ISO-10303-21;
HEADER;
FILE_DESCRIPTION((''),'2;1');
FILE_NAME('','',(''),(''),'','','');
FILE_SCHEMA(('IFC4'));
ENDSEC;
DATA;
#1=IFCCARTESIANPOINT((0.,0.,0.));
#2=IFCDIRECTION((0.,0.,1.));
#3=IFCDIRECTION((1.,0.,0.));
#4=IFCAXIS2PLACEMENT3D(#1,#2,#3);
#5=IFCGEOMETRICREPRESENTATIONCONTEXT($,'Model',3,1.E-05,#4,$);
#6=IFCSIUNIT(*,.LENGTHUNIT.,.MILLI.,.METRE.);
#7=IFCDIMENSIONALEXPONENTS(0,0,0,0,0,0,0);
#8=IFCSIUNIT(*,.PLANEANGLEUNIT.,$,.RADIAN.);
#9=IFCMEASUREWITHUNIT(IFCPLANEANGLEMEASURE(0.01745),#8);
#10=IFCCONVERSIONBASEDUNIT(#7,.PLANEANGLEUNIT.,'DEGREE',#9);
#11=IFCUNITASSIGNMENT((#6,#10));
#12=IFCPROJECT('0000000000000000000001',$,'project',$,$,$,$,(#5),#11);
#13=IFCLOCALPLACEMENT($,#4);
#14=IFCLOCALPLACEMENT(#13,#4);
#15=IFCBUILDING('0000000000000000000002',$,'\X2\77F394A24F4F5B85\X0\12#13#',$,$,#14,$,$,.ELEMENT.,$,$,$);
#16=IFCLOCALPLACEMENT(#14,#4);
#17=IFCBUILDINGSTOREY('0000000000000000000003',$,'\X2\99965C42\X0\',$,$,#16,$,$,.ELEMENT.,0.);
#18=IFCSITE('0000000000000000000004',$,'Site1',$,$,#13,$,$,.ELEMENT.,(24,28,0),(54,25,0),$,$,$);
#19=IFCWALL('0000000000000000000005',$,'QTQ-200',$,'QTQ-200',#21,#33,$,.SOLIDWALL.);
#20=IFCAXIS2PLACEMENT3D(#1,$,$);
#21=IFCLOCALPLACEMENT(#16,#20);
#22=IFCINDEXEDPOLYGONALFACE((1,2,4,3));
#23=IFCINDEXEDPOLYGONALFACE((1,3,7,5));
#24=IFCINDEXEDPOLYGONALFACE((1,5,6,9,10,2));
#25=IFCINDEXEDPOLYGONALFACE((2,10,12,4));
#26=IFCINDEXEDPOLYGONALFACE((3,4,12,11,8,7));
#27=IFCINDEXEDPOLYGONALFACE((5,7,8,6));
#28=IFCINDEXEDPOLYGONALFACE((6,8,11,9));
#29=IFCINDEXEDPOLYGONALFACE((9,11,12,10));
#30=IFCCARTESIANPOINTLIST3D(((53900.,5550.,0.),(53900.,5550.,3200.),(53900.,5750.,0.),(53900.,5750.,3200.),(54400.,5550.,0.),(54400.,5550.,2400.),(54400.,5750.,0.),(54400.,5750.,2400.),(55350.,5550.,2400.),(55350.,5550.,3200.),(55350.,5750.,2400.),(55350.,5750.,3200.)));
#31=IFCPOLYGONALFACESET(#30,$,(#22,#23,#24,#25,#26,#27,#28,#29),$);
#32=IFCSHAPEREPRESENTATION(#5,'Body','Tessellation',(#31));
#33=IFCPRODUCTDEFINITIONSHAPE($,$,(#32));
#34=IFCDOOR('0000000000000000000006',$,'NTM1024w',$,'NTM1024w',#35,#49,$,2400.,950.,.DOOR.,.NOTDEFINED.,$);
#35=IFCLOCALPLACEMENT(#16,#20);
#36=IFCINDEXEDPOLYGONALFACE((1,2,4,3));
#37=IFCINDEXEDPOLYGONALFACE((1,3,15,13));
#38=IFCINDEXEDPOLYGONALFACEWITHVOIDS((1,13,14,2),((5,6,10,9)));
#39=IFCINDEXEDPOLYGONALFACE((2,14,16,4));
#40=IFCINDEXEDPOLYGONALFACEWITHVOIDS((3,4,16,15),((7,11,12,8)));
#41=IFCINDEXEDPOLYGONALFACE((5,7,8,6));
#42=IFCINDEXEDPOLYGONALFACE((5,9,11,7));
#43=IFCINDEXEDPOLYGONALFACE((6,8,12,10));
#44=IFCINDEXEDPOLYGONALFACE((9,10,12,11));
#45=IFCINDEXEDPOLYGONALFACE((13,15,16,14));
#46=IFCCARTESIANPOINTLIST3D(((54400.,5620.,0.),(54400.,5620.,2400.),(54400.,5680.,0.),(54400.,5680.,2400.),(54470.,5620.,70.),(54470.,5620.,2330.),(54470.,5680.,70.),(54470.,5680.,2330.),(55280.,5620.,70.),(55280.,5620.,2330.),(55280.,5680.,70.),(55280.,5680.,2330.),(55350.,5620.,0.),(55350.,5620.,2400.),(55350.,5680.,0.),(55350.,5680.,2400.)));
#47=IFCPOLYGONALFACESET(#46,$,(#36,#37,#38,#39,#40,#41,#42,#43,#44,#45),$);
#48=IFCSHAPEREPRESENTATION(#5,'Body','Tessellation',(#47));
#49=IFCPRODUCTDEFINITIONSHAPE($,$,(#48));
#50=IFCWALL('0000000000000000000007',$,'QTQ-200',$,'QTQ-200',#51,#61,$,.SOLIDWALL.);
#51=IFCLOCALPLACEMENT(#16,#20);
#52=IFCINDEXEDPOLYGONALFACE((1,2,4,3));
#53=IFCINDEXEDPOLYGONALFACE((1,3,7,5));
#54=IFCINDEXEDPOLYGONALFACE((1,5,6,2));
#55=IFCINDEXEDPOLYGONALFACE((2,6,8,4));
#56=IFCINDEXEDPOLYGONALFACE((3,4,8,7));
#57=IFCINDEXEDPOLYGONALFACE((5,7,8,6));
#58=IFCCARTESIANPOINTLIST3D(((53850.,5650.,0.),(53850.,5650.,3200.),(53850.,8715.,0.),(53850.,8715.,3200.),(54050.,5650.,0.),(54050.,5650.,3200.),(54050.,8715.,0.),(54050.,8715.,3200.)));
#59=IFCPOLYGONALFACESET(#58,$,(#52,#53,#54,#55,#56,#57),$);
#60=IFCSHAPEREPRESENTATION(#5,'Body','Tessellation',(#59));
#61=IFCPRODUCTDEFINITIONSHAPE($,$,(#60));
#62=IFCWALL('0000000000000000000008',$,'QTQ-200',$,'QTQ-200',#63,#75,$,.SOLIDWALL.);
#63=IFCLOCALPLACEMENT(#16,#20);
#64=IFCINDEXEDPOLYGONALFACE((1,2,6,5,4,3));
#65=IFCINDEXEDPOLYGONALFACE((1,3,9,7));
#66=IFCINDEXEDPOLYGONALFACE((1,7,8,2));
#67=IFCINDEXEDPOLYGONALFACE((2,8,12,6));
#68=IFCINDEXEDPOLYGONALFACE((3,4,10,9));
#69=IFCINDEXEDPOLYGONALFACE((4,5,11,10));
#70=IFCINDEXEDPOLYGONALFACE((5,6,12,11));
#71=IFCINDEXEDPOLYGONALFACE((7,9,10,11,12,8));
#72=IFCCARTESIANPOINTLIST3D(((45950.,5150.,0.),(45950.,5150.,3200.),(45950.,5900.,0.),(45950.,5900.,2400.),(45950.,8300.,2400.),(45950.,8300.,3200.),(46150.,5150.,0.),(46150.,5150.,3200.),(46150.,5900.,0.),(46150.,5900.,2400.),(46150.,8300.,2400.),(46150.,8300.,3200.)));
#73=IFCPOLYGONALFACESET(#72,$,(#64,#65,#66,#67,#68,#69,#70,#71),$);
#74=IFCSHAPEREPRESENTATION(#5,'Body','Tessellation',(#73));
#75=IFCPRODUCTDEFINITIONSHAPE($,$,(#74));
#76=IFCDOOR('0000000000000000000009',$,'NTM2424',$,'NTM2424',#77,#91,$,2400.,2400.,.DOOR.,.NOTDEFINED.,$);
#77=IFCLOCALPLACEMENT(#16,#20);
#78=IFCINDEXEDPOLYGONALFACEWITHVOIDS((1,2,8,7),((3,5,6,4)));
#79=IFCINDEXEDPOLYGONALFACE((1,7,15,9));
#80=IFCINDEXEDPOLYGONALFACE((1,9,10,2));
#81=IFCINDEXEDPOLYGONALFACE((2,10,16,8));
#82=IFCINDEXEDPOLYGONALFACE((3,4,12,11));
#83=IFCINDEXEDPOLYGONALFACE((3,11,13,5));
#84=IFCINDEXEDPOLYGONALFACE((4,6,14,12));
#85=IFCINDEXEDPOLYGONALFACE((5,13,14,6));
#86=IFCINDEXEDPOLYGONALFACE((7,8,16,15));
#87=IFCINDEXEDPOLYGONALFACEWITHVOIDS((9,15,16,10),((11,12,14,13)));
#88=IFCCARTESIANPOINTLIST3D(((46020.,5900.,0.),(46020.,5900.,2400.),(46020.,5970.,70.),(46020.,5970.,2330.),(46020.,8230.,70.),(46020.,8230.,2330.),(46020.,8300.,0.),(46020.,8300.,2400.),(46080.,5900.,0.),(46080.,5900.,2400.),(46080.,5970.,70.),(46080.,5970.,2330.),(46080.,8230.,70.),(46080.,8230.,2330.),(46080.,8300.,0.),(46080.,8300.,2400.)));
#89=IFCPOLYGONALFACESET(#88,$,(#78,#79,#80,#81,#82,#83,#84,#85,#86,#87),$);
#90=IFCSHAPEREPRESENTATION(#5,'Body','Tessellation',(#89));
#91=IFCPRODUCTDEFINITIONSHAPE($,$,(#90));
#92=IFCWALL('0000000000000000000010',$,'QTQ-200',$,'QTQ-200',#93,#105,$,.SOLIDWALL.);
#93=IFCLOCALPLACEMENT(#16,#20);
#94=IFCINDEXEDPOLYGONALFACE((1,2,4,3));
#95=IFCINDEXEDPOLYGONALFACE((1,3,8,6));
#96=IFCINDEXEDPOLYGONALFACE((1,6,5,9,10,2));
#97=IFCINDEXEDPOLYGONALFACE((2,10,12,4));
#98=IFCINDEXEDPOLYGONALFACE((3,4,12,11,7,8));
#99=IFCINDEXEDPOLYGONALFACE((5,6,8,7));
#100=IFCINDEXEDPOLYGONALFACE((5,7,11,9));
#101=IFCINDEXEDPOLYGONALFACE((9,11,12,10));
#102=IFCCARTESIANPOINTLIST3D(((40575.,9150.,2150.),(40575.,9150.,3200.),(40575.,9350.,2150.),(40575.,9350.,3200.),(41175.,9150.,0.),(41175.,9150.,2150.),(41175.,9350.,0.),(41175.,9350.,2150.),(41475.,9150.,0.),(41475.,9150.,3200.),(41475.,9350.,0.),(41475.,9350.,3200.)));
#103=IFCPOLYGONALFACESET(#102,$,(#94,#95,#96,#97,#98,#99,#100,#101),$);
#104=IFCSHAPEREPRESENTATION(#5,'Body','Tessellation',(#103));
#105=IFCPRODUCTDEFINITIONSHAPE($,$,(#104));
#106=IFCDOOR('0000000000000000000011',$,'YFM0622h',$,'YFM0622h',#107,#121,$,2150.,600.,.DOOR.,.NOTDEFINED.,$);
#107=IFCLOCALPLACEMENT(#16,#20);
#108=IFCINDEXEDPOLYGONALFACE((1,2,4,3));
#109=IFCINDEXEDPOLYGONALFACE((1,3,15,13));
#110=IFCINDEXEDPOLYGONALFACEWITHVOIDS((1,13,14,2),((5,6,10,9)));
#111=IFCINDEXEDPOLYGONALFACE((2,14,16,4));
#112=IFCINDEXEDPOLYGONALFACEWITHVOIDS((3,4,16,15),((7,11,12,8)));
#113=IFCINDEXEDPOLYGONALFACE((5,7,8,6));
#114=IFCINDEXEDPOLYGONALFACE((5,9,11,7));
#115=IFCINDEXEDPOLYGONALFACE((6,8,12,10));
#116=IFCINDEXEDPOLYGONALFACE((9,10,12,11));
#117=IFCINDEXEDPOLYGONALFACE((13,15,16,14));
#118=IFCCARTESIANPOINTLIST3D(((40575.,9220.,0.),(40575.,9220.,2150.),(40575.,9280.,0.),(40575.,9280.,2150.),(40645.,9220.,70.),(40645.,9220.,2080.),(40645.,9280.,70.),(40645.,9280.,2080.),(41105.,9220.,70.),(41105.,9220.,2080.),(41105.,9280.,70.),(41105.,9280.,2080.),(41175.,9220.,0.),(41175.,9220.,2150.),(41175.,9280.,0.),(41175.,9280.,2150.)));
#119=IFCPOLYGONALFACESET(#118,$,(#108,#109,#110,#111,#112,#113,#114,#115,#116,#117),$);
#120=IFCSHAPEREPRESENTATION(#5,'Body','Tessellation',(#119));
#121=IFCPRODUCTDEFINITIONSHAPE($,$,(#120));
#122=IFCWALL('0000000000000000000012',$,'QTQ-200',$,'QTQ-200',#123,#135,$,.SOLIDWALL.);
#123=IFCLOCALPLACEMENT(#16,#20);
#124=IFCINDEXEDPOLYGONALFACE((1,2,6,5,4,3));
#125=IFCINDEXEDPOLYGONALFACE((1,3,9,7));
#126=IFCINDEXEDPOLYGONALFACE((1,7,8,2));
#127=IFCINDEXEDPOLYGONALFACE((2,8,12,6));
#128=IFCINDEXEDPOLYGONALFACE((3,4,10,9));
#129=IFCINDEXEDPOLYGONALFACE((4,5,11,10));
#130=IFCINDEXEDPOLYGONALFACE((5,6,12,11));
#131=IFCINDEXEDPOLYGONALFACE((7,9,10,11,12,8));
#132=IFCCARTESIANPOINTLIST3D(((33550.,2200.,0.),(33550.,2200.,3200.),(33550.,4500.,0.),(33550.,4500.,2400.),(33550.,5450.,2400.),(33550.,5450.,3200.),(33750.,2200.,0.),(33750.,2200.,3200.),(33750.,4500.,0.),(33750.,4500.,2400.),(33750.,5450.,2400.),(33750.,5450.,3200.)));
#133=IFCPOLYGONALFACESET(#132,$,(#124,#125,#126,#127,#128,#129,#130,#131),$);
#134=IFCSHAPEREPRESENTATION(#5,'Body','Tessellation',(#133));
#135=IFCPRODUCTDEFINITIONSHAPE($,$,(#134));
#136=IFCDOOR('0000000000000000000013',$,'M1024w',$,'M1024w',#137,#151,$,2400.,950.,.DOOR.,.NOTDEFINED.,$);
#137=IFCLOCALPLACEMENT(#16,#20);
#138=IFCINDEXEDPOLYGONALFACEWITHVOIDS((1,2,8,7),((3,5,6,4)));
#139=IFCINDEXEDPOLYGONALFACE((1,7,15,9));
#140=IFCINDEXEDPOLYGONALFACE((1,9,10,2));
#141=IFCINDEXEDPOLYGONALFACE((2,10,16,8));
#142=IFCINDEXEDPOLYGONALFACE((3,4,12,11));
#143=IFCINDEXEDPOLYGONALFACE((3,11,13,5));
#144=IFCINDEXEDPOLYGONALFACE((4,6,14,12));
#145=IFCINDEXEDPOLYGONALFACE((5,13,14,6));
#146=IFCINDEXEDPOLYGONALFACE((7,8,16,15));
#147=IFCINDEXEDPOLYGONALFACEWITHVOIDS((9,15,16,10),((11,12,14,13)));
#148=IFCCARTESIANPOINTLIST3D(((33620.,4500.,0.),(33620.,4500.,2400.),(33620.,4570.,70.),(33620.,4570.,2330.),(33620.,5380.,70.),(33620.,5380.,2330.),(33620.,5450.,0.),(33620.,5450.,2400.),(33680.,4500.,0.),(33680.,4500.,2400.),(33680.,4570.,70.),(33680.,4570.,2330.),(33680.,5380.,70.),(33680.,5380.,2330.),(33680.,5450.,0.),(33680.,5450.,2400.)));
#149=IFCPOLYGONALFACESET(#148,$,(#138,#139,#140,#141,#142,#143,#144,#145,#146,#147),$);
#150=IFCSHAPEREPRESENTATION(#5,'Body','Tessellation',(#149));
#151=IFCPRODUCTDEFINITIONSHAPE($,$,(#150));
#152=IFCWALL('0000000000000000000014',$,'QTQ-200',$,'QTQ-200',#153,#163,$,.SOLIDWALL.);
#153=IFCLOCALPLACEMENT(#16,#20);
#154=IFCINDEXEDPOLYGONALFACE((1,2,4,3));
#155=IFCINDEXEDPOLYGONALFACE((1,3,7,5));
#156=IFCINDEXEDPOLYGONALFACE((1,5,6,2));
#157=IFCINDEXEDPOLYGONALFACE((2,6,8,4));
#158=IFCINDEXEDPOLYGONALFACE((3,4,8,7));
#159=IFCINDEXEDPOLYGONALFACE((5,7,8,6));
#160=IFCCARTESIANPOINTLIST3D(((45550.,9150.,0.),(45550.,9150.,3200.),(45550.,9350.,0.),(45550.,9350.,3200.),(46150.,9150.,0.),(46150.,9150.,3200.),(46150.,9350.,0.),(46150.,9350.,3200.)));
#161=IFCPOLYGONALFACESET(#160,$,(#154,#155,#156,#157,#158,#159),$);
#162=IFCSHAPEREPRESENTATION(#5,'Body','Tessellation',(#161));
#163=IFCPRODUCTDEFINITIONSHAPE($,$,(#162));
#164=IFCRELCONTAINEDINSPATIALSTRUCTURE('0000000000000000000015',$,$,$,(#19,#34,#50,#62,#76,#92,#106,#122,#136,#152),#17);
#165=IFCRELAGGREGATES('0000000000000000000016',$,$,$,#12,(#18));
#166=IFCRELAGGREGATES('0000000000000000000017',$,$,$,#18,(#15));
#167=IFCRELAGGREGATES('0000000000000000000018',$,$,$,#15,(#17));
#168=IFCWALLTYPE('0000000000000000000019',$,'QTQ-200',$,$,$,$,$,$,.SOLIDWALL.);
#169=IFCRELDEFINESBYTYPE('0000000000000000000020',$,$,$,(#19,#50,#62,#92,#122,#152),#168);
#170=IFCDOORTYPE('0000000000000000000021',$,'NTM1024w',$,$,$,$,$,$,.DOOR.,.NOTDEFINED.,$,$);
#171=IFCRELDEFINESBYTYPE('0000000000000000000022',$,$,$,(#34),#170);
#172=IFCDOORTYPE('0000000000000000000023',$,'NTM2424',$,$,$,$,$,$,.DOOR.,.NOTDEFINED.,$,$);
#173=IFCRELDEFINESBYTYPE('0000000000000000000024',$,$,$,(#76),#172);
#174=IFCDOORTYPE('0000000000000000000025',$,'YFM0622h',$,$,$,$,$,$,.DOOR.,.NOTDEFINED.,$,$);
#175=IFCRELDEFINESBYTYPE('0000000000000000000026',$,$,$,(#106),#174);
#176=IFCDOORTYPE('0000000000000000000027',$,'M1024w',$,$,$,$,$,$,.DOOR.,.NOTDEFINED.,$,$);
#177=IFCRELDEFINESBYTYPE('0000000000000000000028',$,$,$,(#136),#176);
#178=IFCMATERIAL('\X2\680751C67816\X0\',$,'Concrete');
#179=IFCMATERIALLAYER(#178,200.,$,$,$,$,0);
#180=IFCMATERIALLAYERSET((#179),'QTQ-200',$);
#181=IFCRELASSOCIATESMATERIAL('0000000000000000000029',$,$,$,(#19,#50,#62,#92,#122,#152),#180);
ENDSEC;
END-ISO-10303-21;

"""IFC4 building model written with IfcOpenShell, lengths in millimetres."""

from ifc_helpers import new_model, entity, si_unit, converted_unit, frame, origin_with_axes, place, context, project, spatial, polyline, outline, extrude, material, layer, layer_set, type_object, element, fill, save


model = new_model("IFC4")

# Units and contexts
model_context = context("Model", 3, precision=1e-05, world=origin_with_axes())
ifc_project = project(units=[si_unit("LENGTHUNIT", "METRE", prefix="MILLI"), converted_unit("PLANEANGLEUNIT", "DEGREE", entity("IfcPlaneAngleMeasure", 0.01745), si_unit("PLANEANGLEUNIT", "RADIAN"), dimensions=[0, 0, 0, 0, 0, 0, 0])], contexts=[model_context])

# Site, building, storey
site_placement = place(None, origin_with_axes())
site = spatial("IfcSite", under=ifc_project, at=site_placement, Name="Site1", CompositionType="ELEMENT", RefLatitude=(24, 28, 0), RefLongitude=(54, 25, 0))
building_placement = place(site_placement, origin_with_axes())
building = spatial("IfcBuilding", under=site, at=building_placement, Name="石钢住宅12#13#", CompositionType="ELEMENT")
storey_placement = place(building_placement, origin_with_axes())
storey = spatial("IfcBuildingStorey", under=building, at=storey_placement, Name="首层", CompositionType="ELEMENT", Elevation=0.0)

# Shared definitions
ifc_material = material(Name="标准砖", Category="Concrete")
ifc_layer = layer(ifc_material, 200.0, Priority=0)
ifc_layer_set = layer_set([ifc_layer], Name="QTQ-200")
wall_type = type_object("IfcWallType", Name="QTQ-200", PredefinedType="SOLIDWALL")
door_type_1 = type_object("IfcDoorType", Name="M1024w", OperationType="NOTDEFINED", PredefinedType="DOOR")

# Shared definitions
door_type_2 = type_object("IfcDoorType", Name="NTM2424", OperationType="NOTDEFINED", PredefinedType="DOOR")

# Wall, opening, door
wall_1_placement = place(storey_placement, origin_with_axes())
wall_1 = element("IfcWall", 1, at=wall_1_placement, inside=storey, type_object=wall_type, material=ifc_layer_set, Name="QTQ-200", ObjectType="QTQ-200", PredefinedType="SOLIDWALL", context=model_context, shape_type="SweptSolid", body=[
    extrude(outline(polyline([(0.0, 0.0), (3200.0, 0.0), (3200.0, 1450.0), (0.0, 1450.0), (0.0, 0.0)])), frame((55350.0, 5550.0, 3200.0), z_axis=(0.0, 1.0, 0.0), x_axis=(0.0, 0.0, -1.0)), (0.0, 0.0, 1.0), 200.0),
])
opening_1_placement = place(storey_placement, origin_with_axes())
opening_1 = element("IfcOpeningElement", 2, at=opening_1_placement, cuts=wall_1, PredefinedType="OPENING", context=model_context, shape_type="SweptSolid", body=[
    extrude(outline(polyline([(0.0, 0.0), (950.0, 0.0), (950.0, 2400.0), (0.0, 2400.0), (0.0, 0.0)])), frame((55350.0, 4550.0, 0.0), z_axis=(0.0, 1.0, 0.0), x_axis=(-1.0, 0.0, 0.0)), (0.0, 0.0, 1.0), 2200.0),
])
door_type_3 = type_object("IfcDoorType", Name="NTM1024w", OperationType="NOTDEFINED", PredefinedType="DOOR")
door_1_placement = place(storey_placement, origin_with_axes())
door_1 = element("IfcDoor", 3, at=door_1_placement, inside=storey, type_object=door_type_3, Name="NTM1024w", ObjectType="NTM1024w", OperationType="NOTDEFINED", OverallHeight=2400.0, OverallWidth=950.0, PredefinedType="DOOR", context=model_context, shape_type="SweptSolid", body=[
    extrude(outline(polyline([(-475.0, -1200.0), (475.0, -1200.0), (475.0, 1200.0), (-475.0, 1200.0), (-475.0, -1200.0)]), holes=[polyline([(-405.0, -1130.0), (-405.0, 1130.0), (405.0, 1130.0), (405.0, -1130.0), (-405.0, -1130.0)])]), frame((54875.0, 5620.0, 1200.0), z_axis=(0.0, 1.0, 0.0), x_axis=(-1.0, 0.0, 0.0)), (0.0, 0.0, 1.0), 60.0),
])
fill(opening_1, door_1)

# Wall
wall_2_placement = place(storey_placement, origin_with_axes())
element("IfcWall", 4, at=wall_2_placement, inside=storey, type_object=wall_type, material=ifc_layer_set, Name="QTQ-200", ObjectType="QTQ-200", PredefinedType="SOLIDWALL", context=model_context, shape_type="SweptSolid", body=[
    extrude(outline(polyline([(0.0, 0.0), (3200.0, 0.0), (3200.0, 3065.0), (0.0, 3065.0), (0.0, 0.0)])), frame((53850.0, 5650.0, 3200.0), z_axis=(1.0, 0.0, 0.0), x_axis=(0.0, 0.0, -1.0)), (0.0, 0.0, 1.0), 200.0),
])

# Walls, openings, doors
wall_3_placement = place(storey_placement, origin_with_axes())
wall_3 = element("IfcWall", 5, at=wall_3_placement, inside=storey, type_object=wall_type, material=ifc_layer_set, Name="QTQ-200", ObjectType="QTQ-200", PredefinedType="SOLIDWALL", context=model_context, shape_type="SweptSolid", body=[
    extrude(outline(polyline([(0.0, 0.0), (3200.0, 0.0), (3200.0, 3150.0), (0.0, 3150.0), (0.0, 0.0)])), frame((45950.0, 5150.0, 3200.0), z_axis=(1.0, 0.0, 0.0), x_axis=(0.0, 0.0, -1.0)), (0.0, 0.0, 1.0), 200.0),
])
opening_2_placement = place(storey_placement, origin_with_axes())
opening_2 = element("IfcOpeningElement", 6, at=opening_2_placement, cuts=wall_3, PredefinedType="OPENING", context=model_context, shape_type="SweptSolid", body=[
    extrude(outline(polyline([(0.0, 0.0), (2400.0, 0.0), (2400.0, 2400.0), (0.0, 2400.0), (0.0, 0.0)])), frame((44950.0, 5900.0, 0.0), z_axis=(1.0, 0.0, 0.0), x_axis=(0.0, 1.0, 0.0)), (0.0, 0.0, 1.0), 2200.0),
])
door_2_placement = place(storey_placement, origin_with_axes())
door_2 = element("IfcDoor", 7, at=door_2_placement, inside=storey, type_object=door_type_2, Name="NTM2424", ObjectType="NTM2424", OperationType="NOTDEFINED", OverallHeight=2400.0, OverallWidth=2400.0, PredefinedType="DOOR", context=model_context, shape_type="SweptSolid", body=[
    extrude(outline(polyline([(-1200.0, -1200.0), (1200.0, -1200.0), (1200.0, 1200.0), (-1200.0, 1200.0), (-1200.0, -1200.0)]), holes=[polyline([(-1130.0, -1130.0), (-1130.0, 1130.0), (1130.0, 1130.0), (1130.0, -1130.0), (-1130.0, -1130.0)])]), frame((46020.0, 7100.0, 1200.0), z_axis=(1.0, 0.0, 0.0), x_axis=(0.0, 1.0, 0.0)), (0.0, 0.0, 1.0), 60.0),
])
fill(opening_2, door_2)
wall_4_placement = place(storey_placement, origin_with_axes())
wall_4 = element("IfcWall", 8, at=wall_4_placement, inside=storey, type_object=wall_type, material=ifc_layer_set, Name="QTQ-200", ObjectType="QTQ-200", PredefinedType="SOLIDWALL", context=model_context, shape_type="SweptSolid", body=[
    extrude(outline(polyline([(0.0, 0.0), (3200.0, 0.0), (3200.0, 900.0), (0.0, 900.0), (0.0, 0.0)])), frame((41475.0, 9150.0, 3200.0), z_axis=(0.0, 1.0, 0.0), x_axis=(0.0, 0.0, -1.0)), (0.0, 0.0, 1.0), 200.0),
])
opening_3_placement = place(storey_placement, origin_with_axes())
opening_3 = element("IfcOpeningElement", 9, at=opening_3_placement, cuts=wall_4, PredefinedType="OPENING", context=model_context, shape_type="SweptSolid", body=[
    extrude(outline(polyline([(0.0, 0.0), (600.0, 0.0), (600.0, 2150.0), (0.0, 2150.0), (0.0, 0.0)])), frame((41175.0, 8150.0, 0.0), z_axis=(0.0, 1.0, 0.0), x_axis=(-1.0, 0.0, 0.0)), (0.0, 0.0, 1.0), 2200.0),
])
door_type_4 = type_object("IfcDoorType", Name="YFM0622h", OperationType="NOTDEFINED", PredefinedType="DOOR")
door_3_placement = place(storey_placement, origin_with_axes())
door_3 = element("IfcDoor", 10, at=door_3_placement, inside=storey, type_object=door_type_4, Name="YFM0622h", ObjectType="YFM0622h", OperationType="NOTDEFINED", OverallHeight=2150.0, OverallWidth=600.0, PredefinedType="DOOR", context=model_context, shape_type="SweptSolid", body=[
    extrude(outline(polyline([(-300.0, -1075.0), (300.0, -1075.0), (300.0, 1075.0), (-300.0, 1075.0), (-300.0, -1075.0)]), holes=[polyline([(-230.0, -1005.0), (-230.0, 1005.0), (230.0, 1005.0), (230.0, -1005.0), (-230.0, -1005.0)])]), frame((40875.0, 9220.0, 1075.0), z_axis=(0.0, 1.0, 0.0), x_axis=(-1.0, 0.0, 0.0)), (0.0, 0.0, 1.0), 60.0),
])
fill(opening_3, door_3)
wall_5_placement = place(storey_placement, origin_with_axes())
wall_5 = element("IfcWall", 11, at=wall_5_placement, inside=storey, type_object=wall_type, material=ifc_layer_set, Name="QTQ-200", ObjectType="QTQ-200", PredefinedType="SOLIDWALL", context=model_context, shape_type="SweptSolid", body=[
    extrude(outline(polyline([(0.0, 0.0), (3200.0, 0.0), (3200.0, 3250.0), (0.0, 3250.0), (0.0, 0.0)])), frame((33750.0, 5450.0, 3200.0), z_axis=(-1.0, 0.0, 0.0), x_axis=(0.0, 0.0, -1.0)), (0.0, 0.0, 1.0), 200.0),
])
opening_4_placement = place(storey_placement, origin_with_axes())
opening_4 = element("IfcOpeningElement", 12, at=opening_4_placement, cuts=wall_5, PredefinedType="OPENING", context=model_context, shape_type="SweptSolid", body=[
    extrude(outline(polyline([(0.0, 0.0), (950.0, 0.0), (950.0, 2400.0), (0.0, 2400.0), (0.0, 0.0)])), frame((34750.0, 5450.0, 0.0), z_axis=(-1.0, 0.0, 0.0), x_axis=(0.0, -1.0, 0.0)), (0.0, 0.0, 1.0), 2200.0),
])
door_4_placement = place(storey_placement, origin_with_axes())
door_4 = element("IfcDoor", 13, at=door_4_placement, inside=storey, type_object=door_type_1, Name="M1024w", ObjectType="M1024w", OperationType="NOTDEFINED", OverallHeight=2400.0, OverallWidth=950.0, PredefinedType="DOOR", context=model_context, shape_type="SweptSolid", body=[
    extrude(outline(polyline([(-475.0, -1200.0), (475.0, -1200.0), (475.0, 1200.0), (-475.0, 1200.0), (-475.0, -1200.0)]), holes=[polyline([(-405.0, -1130.0), (-405.0, 1130.0), (405.0, 1130.0), (405.0, -1130.0), (-405.0, -1130.0)])]), frame((33680.0, 4975.0, 1200.0), z_axis=(-1.0, 0.0, 0.0), x_axis=(0.0, -1.0, 0.0)), (0.0, 0.0, 1.0), 60.0),
])
fill(opening_4, door_4)

# Wall
wall_6_placement = place(storey_placement, origin_with_axes())
element("IfcWall", 14, at=wall_6_placement, inside=storey, type_object=wall_type, material=ifc_layer_set, Name="QTQ-200", ObjectType="QTQ-200", PredefinedType="SOLIDWALL", context=model_context, shape_type="SweptSolid", body=[
    extrude(outline(polyline([(0.0, 0.0), (3200.0, 0.0), (3200.0, 600.0), (0.0, 600.0), (0.0, 0.0)])), frame((46150.0, 9150.0, 3200.0), z_axis=(0.0, 1.0, 0.0), x_axis=(0.0, 0.0, -1.0)), (0.0, 0.0, 1.0), 200.0),
])

save(model, "model.ifc")
